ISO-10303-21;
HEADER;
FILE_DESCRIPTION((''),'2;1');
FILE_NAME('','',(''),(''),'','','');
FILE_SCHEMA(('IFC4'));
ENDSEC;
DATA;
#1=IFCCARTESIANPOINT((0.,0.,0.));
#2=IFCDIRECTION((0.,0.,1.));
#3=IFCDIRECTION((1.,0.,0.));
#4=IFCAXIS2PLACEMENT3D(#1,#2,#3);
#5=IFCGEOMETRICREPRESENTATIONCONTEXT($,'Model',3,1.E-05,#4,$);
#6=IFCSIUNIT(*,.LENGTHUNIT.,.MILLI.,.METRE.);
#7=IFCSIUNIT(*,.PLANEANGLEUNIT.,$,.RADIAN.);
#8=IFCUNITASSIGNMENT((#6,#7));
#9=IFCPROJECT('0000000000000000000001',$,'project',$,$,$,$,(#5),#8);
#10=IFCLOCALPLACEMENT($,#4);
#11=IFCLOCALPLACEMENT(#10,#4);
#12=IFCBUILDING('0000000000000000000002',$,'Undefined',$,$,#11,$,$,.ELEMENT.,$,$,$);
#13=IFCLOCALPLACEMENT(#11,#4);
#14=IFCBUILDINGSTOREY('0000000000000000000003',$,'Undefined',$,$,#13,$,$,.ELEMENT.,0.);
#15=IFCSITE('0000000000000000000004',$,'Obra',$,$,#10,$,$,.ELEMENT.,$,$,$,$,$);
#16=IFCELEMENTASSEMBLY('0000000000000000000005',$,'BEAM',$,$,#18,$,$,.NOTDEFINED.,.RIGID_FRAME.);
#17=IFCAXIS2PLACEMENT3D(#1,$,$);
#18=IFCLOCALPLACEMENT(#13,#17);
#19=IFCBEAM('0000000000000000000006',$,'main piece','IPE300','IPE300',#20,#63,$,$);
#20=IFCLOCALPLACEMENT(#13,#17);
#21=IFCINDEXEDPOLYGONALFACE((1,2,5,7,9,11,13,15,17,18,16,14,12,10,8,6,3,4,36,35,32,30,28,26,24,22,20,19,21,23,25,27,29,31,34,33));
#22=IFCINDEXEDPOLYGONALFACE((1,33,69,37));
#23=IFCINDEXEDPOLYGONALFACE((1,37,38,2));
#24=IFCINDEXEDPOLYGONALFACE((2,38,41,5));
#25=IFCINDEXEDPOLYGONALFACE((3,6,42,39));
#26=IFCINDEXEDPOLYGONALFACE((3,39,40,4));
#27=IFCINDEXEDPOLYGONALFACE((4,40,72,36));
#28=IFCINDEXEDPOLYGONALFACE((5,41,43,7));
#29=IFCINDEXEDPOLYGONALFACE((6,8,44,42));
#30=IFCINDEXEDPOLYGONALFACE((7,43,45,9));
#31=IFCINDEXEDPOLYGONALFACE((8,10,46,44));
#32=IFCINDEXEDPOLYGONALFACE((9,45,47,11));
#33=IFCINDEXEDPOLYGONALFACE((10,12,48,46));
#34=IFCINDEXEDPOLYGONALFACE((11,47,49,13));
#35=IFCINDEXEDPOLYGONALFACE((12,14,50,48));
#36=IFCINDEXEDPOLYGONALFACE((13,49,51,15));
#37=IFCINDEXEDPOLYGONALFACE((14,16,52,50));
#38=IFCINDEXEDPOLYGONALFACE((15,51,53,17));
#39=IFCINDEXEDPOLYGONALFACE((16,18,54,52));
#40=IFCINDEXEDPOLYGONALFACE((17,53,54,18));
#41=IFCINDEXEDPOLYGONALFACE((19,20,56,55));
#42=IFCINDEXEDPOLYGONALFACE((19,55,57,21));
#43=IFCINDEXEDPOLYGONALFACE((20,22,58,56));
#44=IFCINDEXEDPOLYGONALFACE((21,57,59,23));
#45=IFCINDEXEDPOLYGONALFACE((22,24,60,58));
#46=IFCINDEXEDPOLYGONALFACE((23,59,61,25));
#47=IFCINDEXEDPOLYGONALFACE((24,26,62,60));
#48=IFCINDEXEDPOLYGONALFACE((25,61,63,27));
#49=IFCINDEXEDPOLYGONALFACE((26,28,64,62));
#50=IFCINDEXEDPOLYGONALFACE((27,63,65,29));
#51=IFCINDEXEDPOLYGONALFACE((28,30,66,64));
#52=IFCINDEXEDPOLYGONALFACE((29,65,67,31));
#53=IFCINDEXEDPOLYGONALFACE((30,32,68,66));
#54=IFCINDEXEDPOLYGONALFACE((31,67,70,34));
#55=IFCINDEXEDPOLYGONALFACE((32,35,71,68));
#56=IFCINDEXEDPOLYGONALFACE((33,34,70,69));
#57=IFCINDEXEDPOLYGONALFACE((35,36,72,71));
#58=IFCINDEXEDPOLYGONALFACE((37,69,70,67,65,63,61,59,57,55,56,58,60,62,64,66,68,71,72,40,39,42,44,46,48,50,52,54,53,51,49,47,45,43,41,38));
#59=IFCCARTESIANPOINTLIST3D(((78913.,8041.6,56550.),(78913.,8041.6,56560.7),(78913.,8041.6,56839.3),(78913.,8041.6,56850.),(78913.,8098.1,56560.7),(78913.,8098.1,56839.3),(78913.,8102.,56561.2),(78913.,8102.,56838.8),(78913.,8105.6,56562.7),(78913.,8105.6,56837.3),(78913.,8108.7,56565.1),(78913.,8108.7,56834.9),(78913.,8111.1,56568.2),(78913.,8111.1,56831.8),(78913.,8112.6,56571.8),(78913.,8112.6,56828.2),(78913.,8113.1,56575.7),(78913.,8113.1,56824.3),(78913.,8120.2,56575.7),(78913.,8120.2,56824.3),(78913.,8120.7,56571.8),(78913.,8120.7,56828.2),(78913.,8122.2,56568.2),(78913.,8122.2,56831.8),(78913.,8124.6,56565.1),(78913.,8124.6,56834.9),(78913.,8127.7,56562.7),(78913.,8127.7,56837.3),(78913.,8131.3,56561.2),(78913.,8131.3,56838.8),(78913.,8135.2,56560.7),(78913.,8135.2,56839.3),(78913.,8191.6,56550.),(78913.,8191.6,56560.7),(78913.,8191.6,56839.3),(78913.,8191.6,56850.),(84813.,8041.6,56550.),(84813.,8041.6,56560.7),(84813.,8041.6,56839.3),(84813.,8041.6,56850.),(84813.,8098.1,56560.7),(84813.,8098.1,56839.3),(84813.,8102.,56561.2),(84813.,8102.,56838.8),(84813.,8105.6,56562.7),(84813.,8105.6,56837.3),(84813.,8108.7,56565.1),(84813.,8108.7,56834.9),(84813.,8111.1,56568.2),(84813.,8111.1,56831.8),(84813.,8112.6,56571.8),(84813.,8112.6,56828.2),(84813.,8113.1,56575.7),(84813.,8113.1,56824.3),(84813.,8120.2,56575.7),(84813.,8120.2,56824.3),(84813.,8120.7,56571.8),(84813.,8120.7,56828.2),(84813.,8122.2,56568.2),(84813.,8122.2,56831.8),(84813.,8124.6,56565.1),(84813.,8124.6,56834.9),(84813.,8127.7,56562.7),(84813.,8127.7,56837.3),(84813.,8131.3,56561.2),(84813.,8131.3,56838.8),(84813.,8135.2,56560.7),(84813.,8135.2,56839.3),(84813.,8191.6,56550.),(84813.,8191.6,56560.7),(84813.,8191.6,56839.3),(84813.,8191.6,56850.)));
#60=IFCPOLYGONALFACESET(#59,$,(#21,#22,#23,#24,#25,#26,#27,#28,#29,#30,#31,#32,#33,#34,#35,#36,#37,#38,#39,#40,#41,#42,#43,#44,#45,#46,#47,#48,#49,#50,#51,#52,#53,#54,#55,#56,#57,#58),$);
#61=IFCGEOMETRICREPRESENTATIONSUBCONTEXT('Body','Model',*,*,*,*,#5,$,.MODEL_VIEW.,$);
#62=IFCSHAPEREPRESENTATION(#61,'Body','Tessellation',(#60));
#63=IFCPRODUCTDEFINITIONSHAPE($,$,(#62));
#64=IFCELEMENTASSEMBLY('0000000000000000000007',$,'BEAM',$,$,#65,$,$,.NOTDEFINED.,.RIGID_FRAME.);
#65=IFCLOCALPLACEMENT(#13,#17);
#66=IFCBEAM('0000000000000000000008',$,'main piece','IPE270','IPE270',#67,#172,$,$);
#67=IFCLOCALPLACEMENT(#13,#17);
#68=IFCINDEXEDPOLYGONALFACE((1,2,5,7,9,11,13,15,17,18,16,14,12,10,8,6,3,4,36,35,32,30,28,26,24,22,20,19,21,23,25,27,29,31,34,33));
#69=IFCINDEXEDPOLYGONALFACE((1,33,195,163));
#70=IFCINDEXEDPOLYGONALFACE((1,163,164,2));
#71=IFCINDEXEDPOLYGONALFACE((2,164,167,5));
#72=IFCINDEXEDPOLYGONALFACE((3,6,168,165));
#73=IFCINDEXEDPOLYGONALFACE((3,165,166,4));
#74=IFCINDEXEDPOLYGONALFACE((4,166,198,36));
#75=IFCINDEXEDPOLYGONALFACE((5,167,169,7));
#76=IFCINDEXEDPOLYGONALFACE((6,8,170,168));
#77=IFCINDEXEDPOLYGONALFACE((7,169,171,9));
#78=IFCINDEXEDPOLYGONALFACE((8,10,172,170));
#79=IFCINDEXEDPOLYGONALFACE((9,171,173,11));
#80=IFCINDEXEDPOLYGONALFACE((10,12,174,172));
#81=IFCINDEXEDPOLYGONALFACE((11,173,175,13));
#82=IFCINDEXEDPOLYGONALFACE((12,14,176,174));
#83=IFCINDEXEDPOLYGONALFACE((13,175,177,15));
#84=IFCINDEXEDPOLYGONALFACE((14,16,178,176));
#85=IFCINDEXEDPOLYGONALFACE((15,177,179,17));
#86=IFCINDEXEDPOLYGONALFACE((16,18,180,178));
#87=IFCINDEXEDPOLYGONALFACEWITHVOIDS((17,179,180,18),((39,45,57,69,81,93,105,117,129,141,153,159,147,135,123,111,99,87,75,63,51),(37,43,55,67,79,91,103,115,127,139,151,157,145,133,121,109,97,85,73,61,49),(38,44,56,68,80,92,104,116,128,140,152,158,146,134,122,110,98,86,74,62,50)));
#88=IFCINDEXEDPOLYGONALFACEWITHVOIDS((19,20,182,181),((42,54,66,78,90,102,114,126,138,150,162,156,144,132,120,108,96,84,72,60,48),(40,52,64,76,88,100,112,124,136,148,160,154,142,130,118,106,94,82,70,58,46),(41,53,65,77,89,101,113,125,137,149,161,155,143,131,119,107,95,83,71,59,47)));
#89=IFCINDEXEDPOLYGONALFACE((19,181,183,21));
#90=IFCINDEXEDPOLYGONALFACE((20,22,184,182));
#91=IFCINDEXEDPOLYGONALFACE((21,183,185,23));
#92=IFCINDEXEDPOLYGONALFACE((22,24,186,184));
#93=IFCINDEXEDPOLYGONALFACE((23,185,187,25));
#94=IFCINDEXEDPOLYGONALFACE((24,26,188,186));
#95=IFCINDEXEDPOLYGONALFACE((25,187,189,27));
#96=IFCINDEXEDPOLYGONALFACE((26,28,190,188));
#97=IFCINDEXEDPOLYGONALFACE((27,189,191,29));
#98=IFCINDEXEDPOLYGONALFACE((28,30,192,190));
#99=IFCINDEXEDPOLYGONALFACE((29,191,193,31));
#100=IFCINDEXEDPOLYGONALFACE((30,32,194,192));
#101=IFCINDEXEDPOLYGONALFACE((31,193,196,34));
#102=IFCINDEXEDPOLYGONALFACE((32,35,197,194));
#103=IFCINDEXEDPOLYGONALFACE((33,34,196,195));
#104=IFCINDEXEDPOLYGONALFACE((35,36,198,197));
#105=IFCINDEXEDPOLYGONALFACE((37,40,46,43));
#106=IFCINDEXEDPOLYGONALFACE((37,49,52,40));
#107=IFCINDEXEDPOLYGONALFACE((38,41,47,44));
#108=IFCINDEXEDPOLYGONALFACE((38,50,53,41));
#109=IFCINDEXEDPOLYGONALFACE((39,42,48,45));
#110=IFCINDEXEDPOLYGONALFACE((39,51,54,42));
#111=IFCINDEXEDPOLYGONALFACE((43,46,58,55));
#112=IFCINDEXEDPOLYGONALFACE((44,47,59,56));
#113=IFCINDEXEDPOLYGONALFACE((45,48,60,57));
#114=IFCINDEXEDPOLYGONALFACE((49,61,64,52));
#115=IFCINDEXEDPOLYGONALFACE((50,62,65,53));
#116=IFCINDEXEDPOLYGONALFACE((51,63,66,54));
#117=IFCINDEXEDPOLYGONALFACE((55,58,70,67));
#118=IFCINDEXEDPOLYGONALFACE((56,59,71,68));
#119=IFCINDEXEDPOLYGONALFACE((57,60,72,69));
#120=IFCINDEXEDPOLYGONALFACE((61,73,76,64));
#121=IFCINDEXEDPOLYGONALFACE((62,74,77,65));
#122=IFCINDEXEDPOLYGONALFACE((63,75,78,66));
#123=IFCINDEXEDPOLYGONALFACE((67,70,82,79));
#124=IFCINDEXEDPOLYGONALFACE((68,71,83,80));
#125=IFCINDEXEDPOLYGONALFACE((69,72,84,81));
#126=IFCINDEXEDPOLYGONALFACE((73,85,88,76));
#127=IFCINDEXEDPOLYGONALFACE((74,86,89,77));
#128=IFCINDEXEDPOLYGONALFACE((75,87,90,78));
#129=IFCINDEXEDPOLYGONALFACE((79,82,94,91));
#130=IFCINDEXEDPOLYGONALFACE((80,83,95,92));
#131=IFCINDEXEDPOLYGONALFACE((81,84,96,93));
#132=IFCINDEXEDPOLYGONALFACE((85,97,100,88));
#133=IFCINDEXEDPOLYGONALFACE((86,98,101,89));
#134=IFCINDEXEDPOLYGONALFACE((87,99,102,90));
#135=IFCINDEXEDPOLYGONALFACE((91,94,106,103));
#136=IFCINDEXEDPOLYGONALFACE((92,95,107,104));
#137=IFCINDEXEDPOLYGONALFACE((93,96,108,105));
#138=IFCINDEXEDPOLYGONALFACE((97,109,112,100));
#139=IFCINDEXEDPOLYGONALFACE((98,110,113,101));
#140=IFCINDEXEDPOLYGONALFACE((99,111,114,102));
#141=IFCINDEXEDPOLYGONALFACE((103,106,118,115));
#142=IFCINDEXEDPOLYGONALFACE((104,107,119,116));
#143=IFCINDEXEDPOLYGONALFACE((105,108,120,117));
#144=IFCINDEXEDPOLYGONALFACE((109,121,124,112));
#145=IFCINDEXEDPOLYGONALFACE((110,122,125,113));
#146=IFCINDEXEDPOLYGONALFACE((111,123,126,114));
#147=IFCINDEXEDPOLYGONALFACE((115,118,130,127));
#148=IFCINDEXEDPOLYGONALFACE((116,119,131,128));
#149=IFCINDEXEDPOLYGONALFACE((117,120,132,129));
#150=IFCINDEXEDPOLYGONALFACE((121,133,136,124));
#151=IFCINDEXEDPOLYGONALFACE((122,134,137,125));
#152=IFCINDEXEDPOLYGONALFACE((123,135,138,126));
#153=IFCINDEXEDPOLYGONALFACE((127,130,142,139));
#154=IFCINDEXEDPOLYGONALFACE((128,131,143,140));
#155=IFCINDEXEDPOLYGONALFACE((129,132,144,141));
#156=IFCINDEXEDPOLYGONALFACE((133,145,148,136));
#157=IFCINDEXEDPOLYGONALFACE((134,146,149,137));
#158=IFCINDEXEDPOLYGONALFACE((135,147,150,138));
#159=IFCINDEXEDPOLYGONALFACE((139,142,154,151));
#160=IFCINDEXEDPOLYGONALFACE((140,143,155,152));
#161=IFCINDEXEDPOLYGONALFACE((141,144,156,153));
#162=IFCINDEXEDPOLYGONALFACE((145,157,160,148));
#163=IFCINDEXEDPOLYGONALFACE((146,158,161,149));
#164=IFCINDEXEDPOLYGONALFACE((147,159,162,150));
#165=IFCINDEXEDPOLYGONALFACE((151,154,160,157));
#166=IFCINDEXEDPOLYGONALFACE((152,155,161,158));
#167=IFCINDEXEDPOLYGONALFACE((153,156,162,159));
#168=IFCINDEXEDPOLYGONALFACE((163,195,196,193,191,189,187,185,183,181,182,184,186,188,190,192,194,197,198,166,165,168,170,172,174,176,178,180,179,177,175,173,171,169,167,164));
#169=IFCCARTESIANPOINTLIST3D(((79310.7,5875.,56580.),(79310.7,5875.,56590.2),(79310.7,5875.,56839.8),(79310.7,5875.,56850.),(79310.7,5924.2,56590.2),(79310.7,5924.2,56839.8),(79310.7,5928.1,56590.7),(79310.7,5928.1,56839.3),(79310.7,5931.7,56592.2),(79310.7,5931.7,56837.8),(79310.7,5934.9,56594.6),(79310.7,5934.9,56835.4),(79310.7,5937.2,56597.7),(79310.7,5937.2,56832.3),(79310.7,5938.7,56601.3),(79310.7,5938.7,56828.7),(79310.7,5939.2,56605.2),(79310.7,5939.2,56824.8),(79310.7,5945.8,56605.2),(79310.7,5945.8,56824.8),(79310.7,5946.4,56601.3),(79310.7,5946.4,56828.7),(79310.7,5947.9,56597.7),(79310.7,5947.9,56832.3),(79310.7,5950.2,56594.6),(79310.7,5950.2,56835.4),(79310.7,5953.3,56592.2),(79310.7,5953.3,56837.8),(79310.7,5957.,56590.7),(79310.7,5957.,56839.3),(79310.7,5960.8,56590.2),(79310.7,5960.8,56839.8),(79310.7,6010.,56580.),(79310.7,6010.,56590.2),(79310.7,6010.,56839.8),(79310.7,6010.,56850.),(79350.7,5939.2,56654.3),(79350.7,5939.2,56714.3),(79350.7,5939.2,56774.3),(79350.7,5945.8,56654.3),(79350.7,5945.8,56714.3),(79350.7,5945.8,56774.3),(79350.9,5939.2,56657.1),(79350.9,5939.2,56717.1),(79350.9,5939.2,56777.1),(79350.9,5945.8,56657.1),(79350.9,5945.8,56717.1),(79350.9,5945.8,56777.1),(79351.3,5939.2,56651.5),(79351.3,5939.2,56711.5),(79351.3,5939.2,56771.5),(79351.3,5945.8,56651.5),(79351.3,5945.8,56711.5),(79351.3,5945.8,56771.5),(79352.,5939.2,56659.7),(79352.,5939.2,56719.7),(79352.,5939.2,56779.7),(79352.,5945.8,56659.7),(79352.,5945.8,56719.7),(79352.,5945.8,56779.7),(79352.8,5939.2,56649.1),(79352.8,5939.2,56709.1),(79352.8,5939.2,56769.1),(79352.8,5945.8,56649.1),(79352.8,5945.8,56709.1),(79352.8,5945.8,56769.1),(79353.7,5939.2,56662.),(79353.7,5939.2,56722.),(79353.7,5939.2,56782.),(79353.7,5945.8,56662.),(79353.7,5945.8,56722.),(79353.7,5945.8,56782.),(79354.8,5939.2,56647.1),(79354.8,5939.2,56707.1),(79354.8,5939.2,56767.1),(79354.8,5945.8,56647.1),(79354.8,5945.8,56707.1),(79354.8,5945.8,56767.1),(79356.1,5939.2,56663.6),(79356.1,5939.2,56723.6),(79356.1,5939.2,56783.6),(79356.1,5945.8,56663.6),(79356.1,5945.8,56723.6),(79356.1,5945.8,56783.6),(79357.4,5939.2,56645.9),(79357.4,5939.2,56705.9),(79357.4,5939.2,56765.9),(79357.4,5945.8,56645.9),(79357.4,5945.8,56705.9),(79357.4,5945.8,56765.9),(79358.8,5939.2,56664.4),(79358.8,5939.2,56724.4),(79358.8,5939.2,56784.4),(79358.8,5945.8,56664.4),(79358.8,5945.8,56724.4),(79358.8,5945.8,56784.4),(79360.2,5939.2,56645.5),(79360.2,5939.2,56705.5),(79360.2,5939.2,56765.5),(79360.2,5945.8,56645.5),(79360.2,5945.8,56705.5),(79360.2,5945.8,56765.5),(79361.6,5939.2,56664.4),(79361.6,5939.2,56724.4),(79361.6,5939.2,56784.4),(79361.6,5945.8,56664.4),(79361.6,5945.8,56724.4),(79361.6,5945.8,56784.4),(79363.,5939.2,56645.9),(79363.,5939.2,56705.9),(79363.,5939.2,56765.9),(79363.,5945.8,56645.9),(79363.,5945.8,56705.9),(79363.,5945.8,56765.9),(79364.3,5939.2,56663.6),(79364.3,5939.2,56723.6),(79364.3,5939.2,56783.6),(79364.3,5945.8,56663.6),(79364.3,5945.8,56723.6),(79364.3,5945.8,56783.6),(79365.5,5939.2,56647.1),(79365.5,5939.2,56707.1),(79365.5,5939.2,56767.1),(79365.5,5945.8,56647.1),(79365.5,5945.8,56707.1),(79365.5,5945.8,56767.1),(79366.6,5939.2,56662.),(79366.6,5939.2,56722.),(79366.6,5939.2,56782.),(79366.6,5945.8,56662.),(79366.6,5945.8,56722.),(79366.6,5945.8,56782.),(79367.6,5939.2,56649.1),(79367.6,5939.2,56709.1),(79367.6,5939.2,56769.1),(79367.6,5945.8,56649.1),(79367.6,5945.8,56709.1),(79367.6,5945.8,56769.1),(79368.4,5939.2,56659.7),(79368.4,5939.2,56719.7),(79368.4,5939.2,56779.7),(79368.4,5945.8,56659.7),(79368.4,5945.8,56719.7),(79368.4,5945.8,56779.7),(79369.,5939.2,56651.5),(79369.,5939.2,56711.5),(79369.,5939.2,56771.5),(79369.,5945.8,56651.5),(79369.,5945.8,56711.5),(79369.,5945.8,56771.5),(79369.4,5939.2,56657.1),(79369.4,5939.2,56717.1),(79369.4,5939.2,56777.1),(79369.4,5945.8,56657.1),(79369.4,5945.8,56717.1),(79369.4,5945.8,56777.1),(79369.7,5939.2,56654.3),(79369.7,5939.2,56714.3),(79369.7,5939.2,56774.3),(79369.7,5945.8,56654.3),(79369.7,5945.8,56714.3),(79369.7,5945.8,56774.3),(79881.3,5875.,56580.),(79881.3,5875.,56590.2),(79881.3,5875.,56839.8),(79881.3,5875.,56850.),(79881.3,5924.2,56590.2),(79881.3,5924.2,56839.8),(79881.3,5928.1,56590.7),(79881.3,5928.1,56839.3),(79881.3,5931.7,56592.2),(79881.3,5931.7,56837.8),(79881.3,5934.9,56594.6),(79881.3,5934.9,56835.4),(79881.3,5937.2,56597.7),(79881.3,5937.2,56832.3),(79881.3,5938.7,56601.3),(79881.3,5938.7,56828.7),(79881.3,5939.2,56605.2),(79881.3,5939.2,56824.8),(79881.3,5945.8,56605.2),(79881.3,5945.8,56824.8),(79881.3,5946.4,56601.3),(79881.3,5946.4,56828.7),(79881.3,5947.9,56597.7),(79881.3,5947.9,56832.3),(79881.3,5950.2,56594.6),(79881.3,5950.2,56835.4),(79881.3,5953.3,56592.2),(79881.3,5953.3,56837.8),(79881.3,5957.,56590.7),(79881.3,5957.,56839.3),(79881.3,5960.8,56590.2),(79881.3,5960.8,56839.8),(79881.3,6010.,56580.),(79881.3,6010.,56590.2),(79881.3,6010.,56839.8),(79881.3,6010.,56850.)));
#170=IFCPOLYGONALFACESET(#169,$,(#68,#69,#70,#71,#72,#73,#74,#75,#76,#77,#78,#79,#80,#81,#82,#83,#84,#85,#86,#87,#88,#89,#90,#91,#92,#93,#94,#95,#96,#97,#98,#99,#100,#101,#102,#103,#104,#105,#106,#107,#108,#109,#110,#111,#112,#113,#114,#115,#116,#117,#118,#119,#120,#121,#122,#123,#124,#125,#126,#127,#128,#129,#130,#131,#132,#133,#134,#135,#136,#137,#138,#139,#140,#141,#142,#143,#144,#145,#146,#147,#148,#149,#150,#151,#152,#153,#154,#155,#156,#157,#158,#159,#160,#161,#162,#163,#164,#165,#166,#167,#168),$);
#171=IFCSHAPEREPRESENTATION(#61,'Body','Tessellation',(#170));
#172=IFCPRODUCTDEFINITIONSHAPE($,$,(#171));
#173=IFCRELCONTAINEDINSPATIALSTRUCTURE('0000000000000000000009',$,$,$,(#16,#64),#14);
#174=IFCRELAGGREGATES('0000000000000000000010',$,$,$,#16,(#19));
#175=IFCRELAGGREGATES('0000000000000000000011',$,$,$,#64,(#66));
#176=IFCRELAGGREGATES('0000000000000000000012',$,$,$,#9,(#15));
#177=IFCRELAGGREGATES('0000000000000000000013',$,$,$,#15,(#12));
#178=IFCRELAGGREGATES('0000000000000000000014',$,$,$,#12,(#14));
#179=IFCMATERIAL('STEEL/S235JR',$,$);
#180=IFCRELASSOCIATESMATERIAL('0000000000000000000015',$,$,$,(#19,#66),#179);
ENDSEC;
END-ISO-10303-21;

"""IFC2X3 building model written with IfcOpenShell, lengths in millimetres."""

from ifc_helpers import new_model, si_unit, frame, origin_with_axes, origin_2d_with_axis, place, context, subcontext, project, spatial, circle, i_section, extrude, clip, halfspace, source, transform, mapped, material, element, aggregate, save


model = new_model("IFC2X3")

# Units and contexts
model_context = context("Model", 3, precision=1e-05, world=origin_with_axes())
body_context = subcontext(model_context, "Body", "Model", "MODEL_VIEW")
ifc_project = project(units=[si_unit("LENGTHUNIT", "METRE", prefix="MILLI"), si_unit("PLANEANGLEUNIT", "RADIAN")], contexts=[model_context])

# Site, building, storey
site_placement = place(None, origin_with_axes())
site = spatial("IfcSite", under=ifc_project, at=site_placement, Name="Obra", CompositionType="ELEMENT")
building_placement = place(site_placement, origin_with_axes())
building = spatial("IfcBuilding", under=site, at=building_placement, Name="Undefined", CompositionType="ELEMENT")
storey_placement = place(building_placement, origin_with_axes())
storey = spatial("IfcBuildingStorey", under=building, at=storey_placement, Name="Undefined", CompositionType="ELEMENT", Elevation=0.0)

# Shared definitions
ifc_material_1 = material(Name="STEEL/S235JR")

# Element assembly, beam
assembly_1_placement = place(storey_placement, origin_with_axes())
assembly_1 = element("IfcElementAssembly", 1, at=assembly_1_placement, inside=storey, Name="BEAM", AssemblyPlace="NOTDEFINED", PredefinedType="RIGID_FRAME")
beam_1_placement = place(assembly_1_placement, frame((78913.0, 8116.6, 56700.0), z_axis=(0.0, 0.0, 1.0), x_axis=(1.0, 0.0, 0.0)))
beam_1 = element("IfcBeam", 2, at=beam_1_placement, material=ifc_material_1, Name="main piece", Description="IPE300", ObjectType="IPE300", context=body_context, shape_type="SweptSolid", body=[
    extrude(i_section(OverallWidth=150.0, OverallDepth=300.0, WebThickness=7.1, FlangeThickness=10.7, FilletRadius=15.0, at=origin_2d_with_axis()), frame((5900.0, 0.0, 0.0), z_axis=(-1.0, 0.0, 0.0), x_axis=(0.0, -1.0, 0.0)), (0.0, 0.0, 1.0), 5900.0),
])
aggregate(assembly_1, [beam_1])

# Element assembly, beam, opening
assembly_2_placement = place(storey_placement, origin_with_axes())
assembly_2 = element("IfcElementAssembly", 3, at=assembly_2_placement, inside=storey, Name="BEAM", AssemblyPlace="NOTDEFINED", PredefinedType="RIGID_FRAME")
beam_2_placement = place(assembly_2_placement, frame((78913.0, 5942.5, 56715.0), z_axis=(0.0, 0.0, 1.0), x_axis=(1.0, 0.0, 0.0)))
beam_2 = element("IfcBeam", 4, at=beam_2_placement, material=ifc_material_1, Name="main piece", Description="IPE270", ObjectType="IPE270", context=body_context, shape_type="Clipping", body=[
    clip(extrude(i_section(OverallWidth=135.0, OverallDepth=270.0, WebThickness=6.6, FlangeThickness=10.2, FilletRadius=15.0, at=origin_2d_with_axis()), frame((968.3, 0.0, 0.0), z_axis=(-1.0, 0.0, 0.0), x_axis=(0.0, -1.0, 0.0)), (0.0, 0.0, 1.0), 968.3), halfspace(frame((397.6, 60.0, -120.0), z_axis=(-1.0, -0.000019, 0.0), x_axis=(0.0, 0.0, 1.0)), False)),
])
shared_shape_1 = source(origin_with_axes(), body_context, "Body", "SweptSolid", [
    extrude(circle(Radius=9.5, at=origin_2d_with_axis()), frame((0.0, -3.4, 0.0), z_axis=(0.0, 1.0, 0.0), x_axis=(1.0, 0.0, 0.0)), (0.0, 0.0, 1.0), 6.8),
])
opening_1_placement = place(assembly_2_placement, frame((79310.2, 5942.5, 56835.0), z_axis=(1.0, 0.0, 0.0), x_axis=(0.0, 0.0, -1.0)))
element("IfcOpeningElement", 5, at=opening_1_placement, cuts=beam_2, ObjectType="Opening", context=body_context, shape_type="MappedRepresentation", body=[
    mapped(shared_shape_1, transform((60.0, 0.0, 50.0))),
    mapped(shared_shape_1, transform((120.0, 0.0, 50.0))),
    mapped(shared_shape_1, transform((180.0, 0.0, 50.0))),
])
aggregate(assembly_2, [beam_2])

save(model, "model.ifc")
